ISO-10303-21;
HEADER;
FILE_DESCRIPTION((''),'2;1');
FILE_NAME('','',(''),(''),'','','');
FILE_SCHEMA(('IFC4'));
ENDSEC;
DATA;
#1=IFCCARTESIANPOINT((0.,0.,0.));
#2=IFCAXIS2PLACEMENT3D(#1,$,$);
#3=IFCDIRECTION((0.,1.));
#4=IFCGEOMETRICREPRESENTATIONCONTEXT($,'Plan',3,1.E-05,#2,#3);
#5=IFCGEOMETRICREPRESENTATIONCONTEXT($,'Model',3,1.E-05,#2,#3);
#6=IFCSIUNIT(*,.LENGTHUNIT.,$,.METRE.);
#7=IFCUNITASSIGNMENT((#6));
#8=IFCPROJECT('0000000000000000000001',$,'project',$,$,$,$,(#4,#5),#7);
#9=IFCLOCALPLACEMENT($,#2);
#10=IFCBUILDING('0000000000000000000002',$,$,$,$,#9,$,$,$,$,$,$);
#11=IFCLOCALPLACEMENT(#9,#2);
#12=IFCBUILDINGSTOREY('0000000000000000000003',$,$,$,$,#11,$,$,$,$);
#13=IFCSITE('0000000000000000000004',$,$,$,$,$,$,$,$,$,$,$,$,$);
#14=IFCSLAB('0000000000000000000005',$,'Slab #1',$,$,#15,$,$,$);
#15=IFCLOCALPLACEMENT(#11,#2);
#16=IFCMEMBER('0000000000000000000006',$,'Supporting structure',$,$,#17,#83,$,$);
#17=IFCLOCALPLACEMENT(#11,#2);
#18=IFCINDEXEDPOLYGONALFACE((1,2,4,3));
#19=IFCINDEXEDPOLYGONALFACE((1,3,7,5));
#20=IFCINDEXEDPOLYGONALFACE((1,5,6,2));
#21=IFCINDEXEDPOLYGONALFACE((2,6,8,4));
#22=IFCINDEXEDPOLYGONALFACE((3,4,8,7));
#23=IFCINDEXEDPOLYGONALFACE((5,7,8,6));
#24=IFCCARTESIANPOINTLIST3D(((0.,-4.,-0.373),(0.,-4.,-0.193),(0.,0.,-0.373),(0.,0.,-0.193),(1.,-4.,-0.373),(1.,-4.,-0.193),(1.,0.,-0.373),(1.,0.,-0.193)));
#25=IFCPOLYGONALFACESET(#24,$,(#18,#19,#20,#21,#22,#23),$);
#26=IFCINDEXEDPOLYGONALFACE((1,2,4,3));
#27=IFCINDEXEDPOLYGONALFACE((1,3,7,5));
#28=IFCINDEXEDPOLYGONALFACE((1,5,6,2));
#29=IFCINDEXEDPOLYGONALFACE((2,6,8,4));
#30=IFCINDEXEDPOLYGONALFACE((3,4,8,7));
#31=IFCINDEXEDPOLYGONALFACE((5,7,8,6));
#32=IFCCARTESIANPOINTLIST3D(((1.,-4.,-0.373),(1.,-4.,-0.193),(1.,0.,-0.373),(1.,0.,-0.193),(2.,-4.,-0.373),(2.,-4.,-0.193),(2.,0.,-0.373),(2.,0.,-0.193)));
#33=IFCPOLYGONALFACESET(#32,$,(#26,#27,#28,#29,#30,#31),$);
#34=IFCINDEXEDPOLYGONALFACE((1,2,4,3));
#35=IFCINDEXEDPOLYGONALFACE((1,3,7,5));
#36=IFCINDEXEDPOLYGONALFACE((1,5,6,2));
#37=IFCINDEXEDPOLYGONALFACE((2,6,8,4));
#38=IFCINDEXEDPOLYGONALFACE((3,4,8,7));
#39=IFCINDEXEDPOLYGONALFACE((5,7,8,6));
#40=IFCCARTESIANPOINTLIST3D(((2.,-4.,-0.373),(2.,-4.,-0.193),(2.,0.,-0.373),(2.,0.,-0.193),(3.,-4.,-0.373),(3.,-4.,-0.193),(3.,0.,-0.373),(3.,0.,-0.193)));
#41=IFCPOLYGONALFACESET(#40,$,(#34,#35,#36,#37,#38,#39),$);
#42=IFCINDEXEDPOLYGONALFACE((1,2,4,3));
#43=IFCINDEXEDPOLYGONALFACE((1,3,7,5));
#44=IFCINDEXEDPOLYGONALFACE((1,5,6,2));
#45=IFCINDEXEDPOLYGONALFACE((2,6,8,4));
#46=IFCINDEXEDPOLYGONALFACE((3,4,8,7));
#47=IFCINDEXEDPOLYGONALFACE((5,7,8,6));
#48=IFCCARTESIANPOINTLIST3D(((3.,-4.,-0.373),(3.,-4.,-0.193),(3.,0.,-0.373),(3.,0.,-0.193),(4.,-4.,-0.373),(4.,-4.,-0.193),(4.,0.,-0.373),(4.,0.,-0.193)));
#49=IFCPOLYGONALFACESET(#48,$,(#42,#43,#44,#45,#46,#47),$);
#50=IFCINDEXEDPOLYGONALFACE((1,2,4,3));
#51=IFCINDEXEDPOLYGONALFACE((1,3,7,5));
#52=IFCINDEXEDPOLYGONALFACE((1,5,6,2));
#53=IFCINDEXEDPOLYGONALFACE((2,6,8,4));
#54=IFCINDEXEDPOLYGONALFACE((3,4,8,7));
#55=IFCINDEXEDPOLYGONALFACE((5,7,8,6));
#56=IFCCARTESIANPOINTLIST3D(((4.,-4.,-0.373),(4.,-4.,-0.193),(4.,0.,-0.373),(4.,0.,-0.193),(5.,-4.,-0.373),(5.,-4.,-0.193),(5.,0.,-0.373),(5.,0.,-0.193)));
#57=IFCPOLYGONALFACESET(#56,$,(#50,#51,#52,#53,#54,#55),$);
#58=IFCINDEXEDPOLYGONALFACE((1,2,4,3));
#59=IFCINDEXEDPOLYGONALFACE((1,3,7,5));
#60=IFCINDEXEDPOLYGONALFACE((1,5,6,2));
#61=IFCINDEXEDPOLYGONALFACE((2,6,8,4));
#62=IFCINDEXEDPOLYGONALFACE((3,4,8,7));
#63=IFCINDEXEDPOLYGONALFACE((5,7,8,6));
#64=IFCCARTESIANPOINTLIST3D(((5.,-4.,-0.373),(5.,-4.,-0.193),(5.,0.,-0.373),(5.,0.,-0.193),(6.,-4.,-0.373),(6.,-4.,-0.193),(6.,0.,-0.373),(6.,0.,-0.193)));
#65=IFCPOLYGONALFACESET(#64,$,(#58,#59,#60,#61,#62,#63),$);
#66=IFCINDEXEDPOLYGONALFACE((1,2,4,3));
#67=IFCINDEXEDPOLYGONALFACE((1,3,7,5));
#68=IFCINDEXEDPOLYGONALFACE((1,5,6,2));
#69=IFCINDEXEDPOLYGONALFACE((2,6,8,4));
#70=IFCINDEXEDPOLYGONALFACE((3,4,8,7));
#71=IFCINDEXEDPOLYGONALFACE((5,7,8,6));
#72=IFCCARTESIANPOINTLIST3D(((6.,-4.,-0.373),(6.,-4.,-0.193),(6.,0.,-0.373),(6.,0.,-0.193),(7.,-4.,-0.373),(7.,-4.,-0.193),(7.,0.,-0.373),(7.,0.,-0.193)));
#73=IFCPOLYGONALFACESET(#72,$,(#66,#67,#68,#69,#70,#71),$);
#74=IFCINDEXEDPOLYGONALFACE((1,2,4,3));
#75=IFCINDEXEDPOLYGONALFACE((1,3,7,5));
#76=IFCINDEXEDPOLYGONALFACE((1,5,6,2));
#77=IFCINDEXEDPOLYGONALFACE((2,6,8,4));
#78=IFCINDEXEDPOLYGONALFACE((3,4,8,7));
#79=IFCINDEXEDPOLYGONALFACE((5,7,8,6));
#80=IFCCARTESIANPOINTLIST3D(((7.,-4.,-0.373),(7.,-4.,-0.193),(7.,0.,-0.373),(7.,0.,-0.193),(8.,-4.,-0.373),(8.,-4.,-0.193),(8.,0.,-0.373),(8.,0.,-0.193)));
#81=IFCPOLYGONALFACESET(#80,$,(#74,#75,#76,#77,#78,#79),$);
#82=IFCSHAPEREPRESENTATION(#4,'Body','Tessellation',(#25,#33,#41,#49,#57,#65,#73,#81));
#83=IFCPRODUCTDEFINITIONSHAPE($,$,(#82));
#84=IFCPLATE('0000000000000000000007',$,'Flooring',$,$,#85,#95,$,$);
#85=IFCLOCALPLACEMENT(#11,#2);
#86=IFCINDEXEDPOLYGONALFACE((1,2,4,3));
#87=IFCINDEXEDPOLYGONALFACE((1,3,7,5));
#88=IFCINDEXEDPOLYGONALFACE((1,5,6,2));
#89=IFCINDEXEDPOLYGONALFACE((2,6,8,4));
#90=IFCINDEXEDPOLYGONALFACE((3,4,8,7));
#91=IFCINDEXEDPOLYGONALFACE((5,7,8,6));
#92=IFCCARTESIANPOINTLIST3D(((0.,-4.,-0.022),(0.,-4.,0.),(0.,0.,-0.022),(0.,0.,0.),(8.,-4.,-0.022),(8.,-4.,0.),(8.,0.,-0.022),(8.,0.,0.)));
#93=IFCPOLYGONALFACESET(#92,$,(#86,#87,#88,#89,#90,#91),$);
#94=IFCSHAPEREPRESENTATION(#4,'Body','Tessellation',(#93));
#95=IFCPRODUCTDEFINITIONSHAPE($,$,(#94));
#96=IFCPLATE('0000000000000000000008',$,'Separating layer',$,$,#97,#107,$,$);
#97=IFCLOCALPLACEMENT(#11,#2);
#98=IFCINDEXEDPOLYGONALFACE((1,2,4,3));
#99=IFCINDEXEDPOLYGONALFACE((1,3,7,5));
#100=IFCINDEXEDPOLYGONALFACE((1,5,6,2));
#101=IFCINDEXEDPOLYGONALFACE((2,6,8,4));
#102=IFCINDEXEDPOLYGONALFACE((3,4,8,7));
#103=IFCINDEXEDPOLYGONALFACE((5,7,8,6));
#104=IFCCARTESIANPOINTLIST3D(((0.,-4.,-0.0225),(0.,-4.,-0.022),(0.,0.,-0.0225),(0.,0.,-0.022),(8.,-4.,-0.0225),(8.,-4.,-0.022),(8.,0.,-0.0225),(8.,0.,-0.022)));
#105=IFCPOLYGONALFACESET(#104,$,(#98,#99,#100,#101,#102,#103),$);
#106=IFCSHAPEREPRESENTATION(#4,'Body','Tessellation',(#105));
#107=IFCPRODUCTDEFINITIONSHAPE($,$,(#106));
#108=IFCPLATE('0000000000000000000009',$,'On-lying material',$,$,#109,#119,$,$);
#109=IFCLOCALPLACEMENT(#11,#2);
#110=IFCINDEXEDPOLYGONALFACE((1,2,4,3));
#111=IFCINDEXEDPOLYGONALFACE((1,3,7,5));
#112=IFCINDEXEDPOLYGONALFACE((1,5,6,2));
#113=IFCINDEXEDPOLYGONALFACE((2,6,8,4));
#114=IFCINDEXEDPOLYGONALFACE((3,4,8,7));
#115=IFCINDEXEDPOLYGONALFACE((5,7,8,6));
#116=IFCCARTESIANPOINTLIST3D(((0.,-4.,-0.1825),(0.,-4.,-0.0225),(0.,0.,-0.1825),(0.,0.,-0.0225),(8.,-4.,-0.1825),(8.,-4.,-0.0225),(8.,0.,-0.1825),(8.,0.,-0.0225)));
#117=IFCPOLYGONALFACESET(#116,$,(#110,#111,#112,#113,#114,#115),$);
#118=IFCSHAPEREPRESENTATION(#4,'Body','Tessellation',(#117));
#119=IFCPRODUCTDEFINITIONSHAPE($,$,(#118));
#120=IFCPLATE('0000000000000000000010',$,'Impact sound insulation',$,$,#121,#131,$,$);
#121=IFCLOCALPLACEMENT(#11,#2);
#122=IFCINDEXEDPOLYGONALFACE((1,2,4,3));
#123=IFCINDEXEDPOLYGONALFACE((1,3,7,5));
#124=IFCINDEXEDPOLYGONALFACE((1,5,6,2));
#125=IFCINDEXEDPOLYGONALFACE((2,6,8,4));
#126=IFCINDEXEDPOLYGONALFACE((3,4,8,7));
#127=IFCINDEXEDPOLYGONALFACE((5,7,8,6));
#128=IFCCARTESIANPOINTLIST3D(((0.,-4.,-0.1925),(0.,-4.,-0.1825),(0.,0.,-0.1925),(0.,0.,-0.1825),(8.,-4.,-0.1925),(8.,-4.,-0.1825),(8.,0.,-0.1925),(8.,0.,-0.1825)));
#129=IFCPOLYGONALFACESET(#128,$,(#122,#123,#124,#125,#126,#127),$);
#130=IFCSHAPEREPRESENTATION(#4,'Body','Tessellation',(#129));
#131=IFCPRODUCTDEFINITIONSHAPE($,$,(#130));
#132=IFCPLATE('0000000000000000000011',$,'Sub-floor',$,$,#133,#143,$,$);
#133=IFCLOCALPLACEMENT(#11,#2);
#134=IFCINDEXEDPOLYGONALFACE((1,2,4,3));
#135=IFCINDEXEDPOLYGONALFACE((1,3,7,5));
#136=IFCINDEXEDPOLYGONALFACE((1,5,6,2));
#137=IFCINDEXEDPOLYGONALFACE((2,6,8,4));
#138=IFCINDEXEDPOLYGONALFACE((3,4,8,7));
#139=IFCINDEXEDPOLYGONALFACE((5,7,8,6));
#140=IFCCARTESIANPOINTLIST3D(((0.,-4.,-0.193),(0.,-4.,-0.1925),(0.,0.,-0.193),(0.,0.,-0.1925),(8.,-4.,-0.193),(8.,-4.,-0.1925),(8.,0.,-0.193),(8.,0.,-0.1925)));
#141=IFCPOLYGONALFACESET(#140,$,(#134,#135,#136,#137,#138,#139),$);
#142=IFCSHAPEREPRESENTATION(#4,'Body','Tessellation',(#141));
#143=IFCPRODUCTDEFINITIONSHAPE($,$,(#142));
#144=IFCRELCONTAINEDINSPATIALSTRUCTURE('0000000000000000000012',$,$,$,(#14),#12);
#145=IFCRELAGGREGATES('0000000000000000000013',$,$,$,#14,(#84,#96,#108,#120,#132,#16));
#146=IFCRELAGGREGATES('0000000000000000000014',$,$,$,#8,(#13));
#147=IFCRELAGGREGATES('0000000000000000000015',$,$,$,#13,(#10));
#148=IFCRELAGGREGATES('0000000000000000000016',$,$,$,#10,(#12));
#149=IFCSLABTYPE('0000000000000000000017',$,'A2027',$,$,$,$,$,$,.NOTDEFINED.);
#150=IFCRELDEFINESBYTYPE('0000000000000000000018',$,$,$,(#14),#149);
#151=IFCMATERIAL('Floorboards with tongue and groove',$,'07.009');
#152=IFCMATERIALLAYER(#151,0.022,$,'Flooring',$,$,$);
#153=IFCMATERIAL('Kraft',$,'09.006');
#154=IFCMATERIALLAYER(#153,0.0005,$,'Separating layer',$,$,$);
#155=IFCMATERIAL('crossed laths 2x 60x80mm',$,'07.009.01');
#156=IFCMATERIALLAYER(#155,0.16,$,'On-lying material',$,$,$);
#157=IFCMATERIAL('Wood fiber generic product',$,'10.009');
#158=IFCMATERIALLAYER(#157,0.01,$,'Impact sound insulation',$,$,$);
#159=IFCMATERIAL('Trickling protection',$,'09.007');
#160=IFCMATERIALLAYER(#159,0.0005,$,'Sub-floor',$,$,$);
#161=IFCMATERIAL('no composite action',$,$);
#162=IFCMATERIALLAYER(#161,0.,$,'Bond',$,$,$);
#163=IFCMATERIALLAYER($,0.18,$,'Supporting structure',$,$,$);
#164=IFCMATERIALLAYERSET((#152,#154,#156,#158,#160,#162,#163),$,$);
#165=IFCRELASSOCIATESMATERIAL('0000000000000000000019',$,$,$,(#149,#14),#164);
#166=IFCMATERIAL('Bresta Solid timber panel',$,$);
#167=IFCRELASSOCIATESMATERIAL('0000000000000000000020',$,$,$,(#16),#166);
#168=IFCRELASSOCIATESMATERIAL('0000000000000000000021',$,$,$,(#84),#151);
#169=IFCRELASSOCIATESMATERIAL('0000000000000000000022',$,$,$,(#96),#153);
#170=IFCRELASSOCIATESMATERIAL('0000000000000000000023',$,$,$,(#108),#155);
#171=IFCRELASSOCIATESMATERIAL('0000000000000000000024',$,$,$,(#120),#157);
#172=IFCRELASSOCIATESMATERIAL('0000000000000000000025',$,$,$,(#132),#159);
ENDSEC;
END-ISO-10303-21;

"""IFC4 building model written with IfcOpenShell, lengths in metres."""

from ifc_helpers import new_model, si_unit, direction, frame, frame_2d, origin, origin_with_axes, place, context, project, spatial, rectangle, extrude, material, layer, layer_set, type_object, element, aggregate, save


model = new_model("IFC4")

# Units and contexts
plan_context = context("Plan", 3, precision=1e-05, world=origin(), true_north=direction((0.0, 1.0)))
model_context = context("Model", 3, precision=1e-05, world=origin(), true_north=direction((0.0, 1.0)))
ifc_project = project(units=[si_unit("LENGTHUNIT", "METRE")], contexts=[plan_context, model_context])

# Site, building, storey
site = spatial("IfcSite", under=ifc_project)
building_placement = place(None, origin())
building = spatial("IfcBuilding", under=site, at=building_placement)
storey_placement = place(building_placement, origin())
storey = spatial("IfcBuildingStorey", under=building, at=storey_placement)

# Slab, member, plates
ifc_material_1 = material(Name="Floorboards with tongue and groove", Category="07.009")
ifc_layer_1 = layer(ifc_material_1, 0.022, Name="Flooring")
ifc_material_2 = material(Name="Kraft", Category="09.006")
ifc_layer_2 = layer(ifc_material_2, 0.0005, Name="Separating layer")
ifc_material_3 = material(Name="crossed laths 2x 60x80mm", Category="07.009.01")
ifc_layer_3 = layer(ifc_material_3, 0.16, Name="On-lying material")
ifc_material_4 = material(Name="Wood fiber generic product", Category="10.009")
ifc_layer_4 = layer(ifc_material_4, 0.01, Name="Impact sound insulation")
ifc_material_5 = material(Name="Trickling protection", Category="09.007")
ifc_layer_5 = layer(ifc_material_5, 0.0005, Name="Sub-floor")
ifc_material_6 = material(Name="no composite action")
ifc_layer_6 = layer(ifc_material_6, 0.0, Name="Bond")
ifc_layer_7 = layer(None, 0.18, Name="Supporting structure")
ifc_layer_set = layer_set([ifc_layer_1, ifc_layer_2, ifc_layer_3, ifc_layer_4, ifc_layer_5, ifc_layer_6, ifc_layer_7])
slab_type = type_object("IfcSlabType", Name="A2027", PredefinedType="NOTDEFINED", material=ifc_layer_set)
slab_placement = place(None, frame((0.0, 0.0, 0.0), z_axis=(0.0, 0.0, -1.0), x_axis=(1.0, 0.0, 0.0)))
slab = element("IfcSlab", 1, at=slab_placement, inside=storey, type_object=slab_type, material=ifc_layer_set, Name="Slab #1")
ifc_material_7 = material(Name="Bresta Solid timber panel")
member_placement = place(slab_placement, origin())
member = element("IfcMember", 2, at=member_placement, material=ifc_material_7, Name="Supporting structure", context=plan_context, shape_type="SweptSolid", body=[
    extrude(rectangle(XDim=1.0, YDim=0.18, at=frame_2d((0.5, 0.09), x_axis=(1.0, 0.0))), frame((0.0, 4.0, 0.193), z_axis=(0.0, -1.0, 0.0), x_axis=(1.0, 0.0, 0.0)), (0.0, 0.0, 1.0), 4.0),
    extrude(rectangle(XDim=1.0, YDim=0.18, at=frame_2d((0.5, 0.09), x_axis=(1.0, 0.0))), frame((1.0, 4.0, 0.193), z_axis=(0.0, -1.0, 0.0), x_axis=(1.0, 0.0, 0.0)), (0.0, 0.0, 1.0), 4.0),
    extrude(rectangle(XDim=1.0, YDim=0.18, at=frame_2d((0.5, 0.09), x_axis=(1.0, 0.0))), frame((2.0, 4.0, 0.193), z_axis=(0.0, -1.0, 0.0), x_axis=(1.0, 0.0, 0.0)), (0.0, 0.0, 1.0), 4.0),
    extrude(rectangle(XDim=1.0, YDim=0.18, at=frame_2d((0.5, 0.09), x_axis=(1.0, 0.0))), frame((3.0, 4.0, 0.193), z_axis=(0.0, -1.0, 0.0), x_axis=(1.0, 0.0, 0.0)), (0.0, 0.0, 1.0), 4.0),
    extrude(rectangle(XDim=1.0, YDim=0.18, at=frame_2d((0.5, 0.09), x_axis=(1.0, 0.0))), frame((4.0, 4.0, 0.193), z_axis=(0.0, -1.0, 0.0), x_axis=(1.0, 0.0, 0.0)), (0.0, 0.0, 1.0), 4.0),
    extrude(rectangle(XDim=1.0, YDim=0.18, at=frame_2d((0.5, 0.09), x_axis=(1.0, 0.0))), frame((5.0, 4.0, 0.193), z_axis=(0.0, -1.0, 0.0), x_axis=(1.0, 0.0, 0.0)), (0.0, 0.0, 1.0), 4.0),
    extrude(rectangle(XDim=1.0, YDim=0.18, at=frame_2d((0.5, 0.09), x_axis=(1.0, 0.0))), frame((6.0, 4.0, 0.193), z_axis=(0.0, -1.0, 0.0), x_axis=(1.0, 0.0, 0.0)), (0.0, 0.0, 1.0), 4.0),
    extrude(rectangle(XDim=1.0, YDim=0.18, at=frame_2d((0.5, 0.09), x_axis=(1.0, 0.0))), frame((7.0, 4.0, 0.193), z_axis=(0.0, -1.0, 0.0), x_axis=(1.0, 0.0, 0.0)), (0.0, 0.0, 1.0), 4.0),
])
plate_1_placement = place(slab_placement, origin())
plate_1 = element("IfcPlate", 3, at=plate_1_placement, material=ifc_material_1, Name="Flooring", context=plan_context, shape_type="SweptSolid", body=[
    extrude(rectangle(XDim=8.0, YDim=4.0, at=frame_2d((4.0, 2.0), x_axis=(1.0, 0.0))), origin_with_axes(), (0.0, 0.0, 1.0), 0.022),
])
plate_2_placement = place(slab_placement, origin())
plate_2 = element("IfcPlate", 4, at=plate_2_placement, material=ifc_material_2, Name="Separating layer", context=plan_context, shape_type="SweptSolid", body=[
    extrude(rectangle(XDim=8.0, YDim=4.0, at=frame_2d((4.0, 2.0), x_axis=(1.0, 0.0))), frame((0.0, 0.0, 0.022), z_axis=(0.0, 0.0, 1.0), x_axis=(1.0, 0.0, 0.0)), (0.0, 0.0, 1.0), 0.0005),
])
plate_3_placement = place(slab_placement, origin())
plate_3 = element("IfcPlate", 5, at=plate_3_placement, material=ifc_material_3, Name="On-lying material", context=plan_context, shape_type="SweptSolid", body=[
    extrude(rectangle(XDim=8.0, YDim=4.0, at=frame_2d((4.0, 2.0), x_axis=(1.0, 0.0))), frame((0.0, 0.0, 0.0225), z_axis=(0.0, 0.0, 1.0), x_axis=(1.0, 0.0, 0.0)), (0.0, 0.0, 1.0), 0.16),
])
plate_4_placement = place(slab_placement, origin())
plate_4 = element("IfcPlate", 6, at=plate_4_placement, material=ifc_material_4, Name="Impact sound insulation", context=plan_context, shape_type="SweptSolid", body=[
    extrude(rectangle(XDim=8.0, YDim=4.0, at=frame_2d((4.0, 2.0), x_axis=(1.0, 0.0))), frame((0.0, 0.0, 0.1825), z_axis=(0.0, 0.0, 1.0), x_axis=(1.0, 0.0, 0.0)), (0.0, 0.0, 1.0), 0.01),
])
plate_5_placement = place(slab_placement, origin())
plate_5 = element("IfcPlate", 7, at=plate_5_placement, material=ifc_material_5, Name="Sub-floor", context=plan_context, shape_type="SweptSolid", body=[
    extrude(rectangle(XDim=8.0, YDim=4.0, at=frame_2d((4.0, 2.0), x_axis=(1.0, 0.0))), frame((0.0, 0.0, 0.1925), z_axis=(0.0, 0.0, 1.0), x_axis=(1.0, 0.0, 0.0)), (0.0, 0.0, 1.0), 0.0005),
])
aggregate(slab, [plate_1, plate_2, plate_3, plate_4, plate_5, member])

save(model, "model.ifc")
